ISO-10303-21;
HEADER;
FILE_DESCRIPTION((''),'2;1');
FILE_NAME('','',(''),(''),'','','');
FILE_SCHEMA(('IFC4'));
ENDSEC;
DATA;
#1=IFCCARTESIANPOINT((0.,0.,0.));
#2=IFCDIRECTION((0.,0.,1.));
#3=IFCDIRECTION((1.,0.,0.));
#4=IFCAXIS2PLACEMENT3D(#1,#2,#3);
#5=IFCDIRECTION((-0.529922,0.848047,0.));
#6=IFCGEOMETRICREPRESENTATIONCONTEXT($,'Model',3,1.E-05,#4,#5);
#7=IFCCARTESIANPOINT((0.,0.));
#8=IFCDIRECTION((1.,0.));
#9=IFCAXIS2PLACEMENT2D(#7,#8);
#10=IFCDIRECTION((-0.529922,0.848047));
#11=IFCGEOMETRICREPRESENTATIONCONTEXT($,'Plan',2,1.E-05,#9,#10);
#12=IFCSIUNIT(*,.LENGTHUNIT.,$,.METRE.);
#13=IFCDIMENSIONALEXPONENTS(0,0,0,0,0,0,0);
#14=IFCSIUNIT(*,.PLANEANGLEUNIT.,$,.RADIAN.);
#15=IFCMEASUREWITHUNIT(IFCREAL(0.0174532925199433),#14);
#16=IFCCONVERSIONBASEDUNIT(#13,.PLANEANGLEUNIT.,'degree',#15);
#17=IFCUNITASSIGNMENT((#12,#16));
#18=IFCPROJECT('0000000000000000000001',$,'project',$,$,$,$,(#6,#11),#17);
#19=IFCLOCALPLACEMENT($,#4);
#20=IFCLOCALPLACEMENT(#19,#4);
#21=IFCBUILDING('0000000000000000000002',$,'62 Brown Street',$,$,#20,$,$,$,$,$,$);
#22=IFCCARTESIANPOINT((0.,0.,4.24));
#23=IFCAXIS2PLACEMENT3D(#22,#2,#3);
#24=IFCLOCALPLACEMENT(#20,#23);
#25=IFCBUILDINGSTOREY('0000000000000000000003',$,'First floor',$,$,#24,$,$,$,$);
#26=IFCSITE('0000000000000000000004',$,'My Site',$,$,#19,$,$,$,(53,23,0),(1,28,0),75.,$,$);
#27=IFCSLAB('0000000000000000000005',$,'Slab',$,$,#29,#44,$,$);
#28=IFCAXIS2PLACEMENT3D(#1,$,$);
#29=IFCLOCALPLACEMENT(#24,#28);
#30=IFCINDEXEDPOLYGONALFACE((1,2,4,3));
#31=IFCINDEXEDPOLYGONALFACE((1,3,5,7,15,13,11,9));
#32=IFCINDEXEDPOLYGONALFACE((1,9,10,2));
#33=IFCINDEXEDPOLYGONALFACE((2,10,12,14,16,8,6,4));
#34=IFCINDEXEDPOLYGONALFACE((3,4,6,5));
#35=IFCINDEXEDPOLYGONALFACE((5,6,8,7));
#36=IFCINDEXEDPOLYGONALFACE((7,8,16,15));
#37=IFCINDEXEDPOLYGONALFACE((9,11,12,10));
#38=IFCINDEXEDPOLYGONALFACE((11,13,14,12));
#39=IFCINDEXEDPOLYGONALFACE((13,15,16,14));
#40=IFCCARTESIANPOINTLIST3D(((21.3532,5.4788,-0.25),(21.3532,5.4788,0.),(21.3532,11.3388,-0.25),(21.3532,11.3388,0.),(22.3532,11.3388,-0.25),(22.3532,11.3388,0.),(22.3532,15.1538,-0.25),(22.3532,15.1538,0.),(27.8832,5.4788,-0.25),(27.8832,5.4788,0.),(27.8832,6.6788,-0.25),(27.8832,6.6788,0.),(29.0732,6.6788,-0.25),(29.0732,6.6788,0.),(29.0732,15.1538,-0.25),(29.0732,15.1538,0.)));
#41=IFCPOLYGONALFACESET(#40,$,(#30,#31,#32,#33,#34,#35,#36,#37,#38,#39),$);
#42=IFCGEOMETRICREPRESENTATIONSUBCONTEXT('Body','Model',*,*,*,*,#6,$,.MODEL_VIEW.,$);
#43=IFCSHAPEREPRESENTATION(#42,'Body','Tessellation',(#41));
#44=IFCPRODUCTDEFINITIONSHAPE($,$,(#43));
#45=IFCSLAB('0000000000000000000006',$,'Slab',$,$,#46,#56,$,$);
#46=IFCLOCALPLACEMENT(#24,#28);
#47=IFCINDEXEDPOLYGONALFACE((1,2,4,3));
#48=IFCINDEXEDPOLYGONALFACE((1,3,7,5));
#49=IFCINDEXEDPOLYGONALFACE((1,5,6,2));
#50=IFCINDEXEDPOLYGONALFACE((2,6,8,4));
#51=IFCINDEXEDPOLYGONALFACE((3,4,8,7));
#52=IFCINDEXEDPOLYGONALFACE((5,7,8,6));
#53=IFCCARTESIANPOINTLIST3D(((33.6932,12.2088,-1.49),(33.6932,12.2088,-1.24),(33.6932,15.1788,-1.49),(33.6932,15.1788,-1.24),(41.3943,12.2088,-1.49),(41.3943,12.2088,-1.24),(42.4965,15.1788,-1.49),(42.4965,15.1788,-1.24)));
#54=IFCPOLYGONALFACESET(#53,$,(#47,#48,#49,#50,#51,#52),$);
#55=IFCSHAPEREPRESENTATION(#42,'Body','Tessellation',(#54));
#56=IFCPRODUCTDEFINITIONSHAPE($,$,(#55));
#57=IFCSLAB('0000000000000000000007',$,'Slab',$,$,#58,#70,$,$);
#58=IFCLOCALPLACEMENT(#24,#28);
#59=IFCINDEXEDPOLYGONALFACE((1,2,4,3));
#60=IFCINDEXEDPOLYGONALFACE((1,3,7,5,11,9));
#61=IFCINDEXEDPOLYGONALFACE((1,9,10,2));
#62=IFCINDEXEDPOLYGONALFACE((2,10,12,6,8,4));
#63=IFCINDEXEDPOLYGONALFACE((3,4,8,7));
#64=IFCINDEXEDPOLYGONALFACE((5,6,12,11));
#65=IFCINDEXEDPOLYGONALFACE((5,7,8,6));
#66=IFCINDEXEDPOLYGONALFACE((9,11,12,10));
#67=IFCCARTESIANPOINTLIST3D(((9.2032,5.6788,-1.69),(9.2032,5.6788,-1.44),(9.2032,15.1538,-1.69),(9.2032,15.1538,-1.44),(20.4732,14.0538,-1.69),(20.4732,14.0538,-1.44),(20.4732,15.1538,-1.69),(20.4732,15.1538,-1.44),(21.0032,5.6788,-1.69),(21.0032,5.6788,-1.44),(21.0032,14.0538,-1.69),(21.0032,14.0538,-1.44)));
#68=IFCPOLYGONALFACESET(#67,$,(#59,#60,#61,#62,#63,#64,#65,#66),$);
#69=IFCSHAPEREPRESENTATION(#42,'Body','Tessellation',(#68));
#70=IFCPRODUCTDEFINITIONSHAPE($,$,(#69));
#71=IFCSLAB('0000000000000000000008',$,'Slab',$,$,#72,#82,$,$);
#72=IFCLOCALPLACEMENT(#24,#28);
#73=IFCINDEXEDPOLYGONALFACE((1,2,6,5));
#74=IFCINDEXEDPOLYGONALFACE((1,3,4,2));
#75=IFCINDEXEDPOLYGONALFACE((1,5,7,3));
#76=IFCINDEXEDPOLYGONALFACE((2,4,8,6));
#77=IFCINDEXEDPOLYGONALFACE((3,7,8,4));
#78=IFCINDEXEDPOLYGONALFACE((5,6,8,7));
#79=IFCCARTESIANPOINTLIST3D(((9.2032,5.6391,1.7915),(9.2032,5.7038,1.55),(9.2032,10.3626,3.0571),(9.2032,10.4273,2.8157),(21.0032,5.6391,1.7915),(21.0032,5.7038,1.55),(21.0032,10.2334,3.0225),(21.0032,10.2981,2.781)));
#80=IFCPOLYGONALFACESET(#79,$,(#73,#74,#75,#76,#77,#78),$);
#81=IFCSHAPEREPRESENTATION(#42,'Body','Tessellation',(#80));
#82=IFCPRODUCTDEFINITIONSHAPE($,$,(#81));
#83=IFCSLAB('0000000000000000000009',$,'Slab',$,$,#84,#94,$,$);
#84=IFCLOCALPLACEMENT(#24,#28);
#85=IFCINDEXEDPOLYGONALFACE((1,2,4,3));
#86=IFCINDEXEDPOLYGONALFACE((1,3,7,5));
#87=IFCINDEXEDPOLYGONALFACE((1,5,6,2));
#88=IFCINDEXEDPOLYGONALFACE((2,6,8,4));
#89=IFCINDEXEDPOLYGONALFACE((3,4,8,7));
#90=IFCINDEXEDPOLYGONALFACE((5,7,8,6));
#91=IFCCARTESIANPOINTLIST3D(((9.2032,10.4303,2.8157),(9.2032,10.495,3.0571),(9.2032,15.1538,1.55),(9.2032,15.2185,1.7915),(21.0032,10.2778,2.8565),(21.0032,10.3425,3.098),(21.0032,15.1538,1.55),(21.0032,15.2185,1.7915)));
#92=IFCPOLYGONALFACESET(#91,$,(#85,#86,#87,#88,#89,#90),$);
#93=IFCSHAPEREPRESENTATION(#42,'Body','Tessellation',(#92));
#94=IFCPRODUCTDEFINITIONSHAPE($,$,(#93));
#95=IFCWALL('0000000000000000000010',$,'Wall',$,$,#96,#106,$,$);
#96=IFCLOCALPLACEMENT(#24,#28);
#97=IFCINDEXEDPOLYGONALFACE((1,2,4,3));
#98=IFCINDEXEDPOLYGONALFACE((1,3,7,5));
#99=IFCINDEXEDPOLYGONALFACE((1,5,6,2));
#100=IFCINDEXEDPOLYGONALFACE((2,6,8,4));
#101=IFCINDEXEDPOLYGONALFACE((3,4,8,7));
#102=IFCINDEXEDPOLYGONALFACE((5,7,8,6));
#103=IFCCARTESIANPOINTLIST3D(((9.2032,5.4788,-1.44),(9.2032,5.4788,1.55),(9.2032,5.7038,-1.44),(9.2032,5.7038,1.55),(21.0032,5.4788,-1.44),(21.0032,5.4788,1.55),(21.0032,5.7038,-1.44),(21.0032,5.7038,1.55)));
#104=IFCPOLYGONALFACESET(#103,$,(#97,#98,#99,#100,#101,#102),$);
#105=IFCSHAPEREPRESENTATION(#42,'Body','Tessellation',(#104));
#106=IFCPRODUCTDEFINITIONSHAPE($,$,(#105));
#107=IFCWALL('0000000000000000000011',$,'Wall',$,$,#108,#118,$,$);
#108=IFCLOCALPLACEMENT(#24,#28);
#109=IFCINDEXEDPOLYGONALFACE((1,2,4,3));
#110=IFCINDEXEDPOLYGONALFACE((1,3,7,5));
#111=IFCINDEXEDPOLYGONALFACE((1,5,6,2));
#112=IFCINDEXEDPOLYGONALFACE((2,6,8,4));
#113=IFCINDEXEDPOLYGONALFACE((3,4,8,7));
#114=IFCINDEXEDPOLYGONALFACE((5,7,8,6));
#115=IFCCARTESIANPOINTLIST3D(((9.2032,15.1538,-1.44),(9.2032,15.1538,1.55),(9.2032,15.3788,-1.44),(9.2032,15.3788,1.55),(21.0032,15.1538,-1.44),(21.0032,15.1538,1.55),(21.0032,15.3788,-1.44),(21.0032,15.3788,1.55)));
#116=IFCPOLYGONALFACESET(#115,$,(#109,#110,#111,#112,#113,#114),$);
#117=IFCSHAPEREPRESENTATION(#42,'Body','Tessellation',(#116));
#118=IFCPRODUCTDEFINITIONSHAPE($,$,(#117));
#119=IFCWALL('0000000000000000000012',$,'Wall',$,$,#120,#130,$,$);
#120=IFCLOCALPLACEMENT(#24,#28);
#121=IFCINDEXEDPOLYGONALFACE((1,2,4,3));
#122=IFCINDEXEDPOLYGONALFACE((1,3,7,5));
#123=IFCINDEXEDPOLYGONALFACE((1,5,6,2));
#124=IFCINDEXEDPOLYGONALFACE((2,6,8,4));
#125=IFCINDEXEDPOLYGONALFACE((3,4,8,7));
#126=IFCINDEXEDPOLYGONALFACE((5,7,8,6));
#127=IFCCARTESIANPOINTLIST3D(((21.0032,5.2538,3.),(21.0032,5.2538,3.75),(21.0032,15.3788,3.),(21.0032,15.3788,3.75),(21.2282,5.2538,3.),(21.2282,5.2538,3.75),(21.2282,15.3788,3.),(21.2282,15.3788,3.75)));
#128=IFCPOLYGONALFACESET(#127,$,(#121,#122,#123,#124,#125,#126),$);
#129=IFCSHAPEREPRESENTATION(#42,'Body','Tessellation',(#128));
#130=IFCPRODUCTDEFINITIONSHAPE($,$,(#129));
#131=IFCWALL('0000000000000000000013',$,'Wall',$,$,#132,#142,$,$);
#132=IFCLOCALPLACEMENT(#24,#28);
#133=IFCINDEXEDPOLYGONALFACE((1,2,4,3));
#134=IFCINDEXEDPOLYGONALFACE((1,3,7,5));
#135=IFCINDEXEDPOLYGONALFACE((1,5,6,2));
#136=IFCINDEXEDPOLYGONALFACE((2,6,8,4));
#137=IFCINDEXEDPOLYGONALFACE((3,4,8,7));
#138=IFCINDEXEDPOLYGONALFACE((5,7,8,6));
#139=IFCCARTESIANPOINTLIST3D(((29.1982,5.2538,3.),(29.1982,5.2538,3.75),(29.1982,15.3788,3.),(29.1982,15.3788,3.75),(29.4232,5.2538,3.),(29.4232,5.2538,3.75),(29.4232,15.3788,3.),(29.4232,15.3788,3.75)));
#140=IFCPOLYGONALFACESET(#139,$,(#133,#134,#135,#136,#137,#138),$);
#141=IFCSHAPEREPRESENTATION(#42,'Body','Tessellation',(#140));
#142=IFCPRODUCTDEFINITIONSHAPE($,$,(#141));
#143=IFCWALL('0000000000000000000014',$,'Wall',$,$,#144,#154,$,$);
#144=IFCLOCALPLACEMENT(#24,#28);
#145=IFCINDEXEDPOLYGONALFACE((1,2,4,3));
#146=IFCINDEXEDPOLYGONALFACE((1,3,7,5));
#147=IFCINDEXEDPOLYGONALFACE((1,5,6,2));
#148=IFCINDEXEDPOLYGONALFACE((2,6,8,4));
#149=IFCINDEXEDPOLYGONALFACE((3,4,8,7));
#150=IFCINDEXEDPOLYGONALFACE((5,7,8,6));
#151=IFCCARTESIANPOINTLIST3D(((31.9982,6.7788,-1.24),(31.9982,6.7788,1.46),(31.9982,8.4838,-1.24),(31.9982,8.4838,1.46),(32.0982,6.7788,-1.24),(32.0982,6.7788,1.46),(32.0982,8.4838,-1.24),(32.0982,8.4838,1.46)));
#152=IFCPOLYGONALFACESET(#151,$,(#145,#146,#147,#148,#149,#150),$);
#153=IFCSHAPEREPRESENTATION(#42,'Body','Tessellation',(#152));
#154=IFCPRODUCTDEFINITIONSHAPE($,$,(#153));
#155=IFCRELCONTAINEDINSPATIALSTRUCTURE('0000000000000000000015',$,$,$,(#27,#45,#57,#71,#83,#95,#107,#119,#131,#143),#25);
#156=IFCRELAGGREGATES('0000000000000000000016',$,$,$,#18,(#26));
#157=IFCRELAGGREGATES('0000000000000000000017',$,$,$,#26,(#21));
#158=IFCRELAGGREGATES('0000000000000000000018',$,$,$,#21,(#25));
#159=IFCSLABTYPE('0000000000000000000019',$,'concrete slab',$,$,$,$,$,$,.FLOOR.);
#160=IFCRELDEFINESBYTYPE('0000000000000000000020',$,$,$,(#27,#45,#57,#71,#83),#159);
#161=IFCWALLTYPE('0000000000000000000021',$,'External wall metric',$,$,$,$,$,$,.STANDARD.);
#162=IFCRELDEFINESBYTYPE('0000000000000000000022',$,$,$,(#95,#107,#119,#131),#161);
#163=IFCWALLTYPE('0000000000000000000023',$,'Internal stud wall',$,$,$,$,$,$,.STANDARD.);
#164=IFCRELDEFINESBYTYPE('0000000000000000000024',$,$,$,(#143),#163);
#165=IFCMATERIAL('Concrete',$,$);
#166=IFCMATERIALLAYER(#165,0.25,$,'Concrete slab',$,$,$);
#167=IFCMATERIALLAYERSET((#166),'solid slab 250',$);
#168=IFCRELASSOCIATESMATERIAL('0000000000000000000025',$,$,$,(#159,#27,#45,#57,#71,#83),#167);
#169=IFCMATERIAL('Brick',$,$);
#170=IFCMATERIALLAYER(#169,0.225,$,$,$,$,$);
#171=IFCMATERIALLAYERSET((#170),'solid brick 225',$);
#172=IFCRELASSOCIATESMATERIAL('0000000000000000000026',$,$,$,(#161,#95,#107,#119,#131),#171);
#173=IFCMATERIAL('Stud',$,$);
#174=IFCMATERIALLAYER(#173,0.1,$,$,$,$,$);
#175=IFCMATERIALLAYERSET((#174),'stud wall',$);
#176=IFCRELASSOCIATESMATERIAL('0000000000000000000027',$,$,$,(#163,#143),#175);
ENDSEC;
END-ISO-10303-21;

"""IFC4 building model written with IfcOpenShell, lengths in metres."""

from ifc_helpers import new_model, entity, si_unit, converted_unit, direction, frame, origin_with_axes, origin_2d_with_axis, place, context, subcontext, project, spatial, line, indexed_curve, outline, extrude, material, layer, layer_set, layer_usage, type_object, element, save


model = new_model("IFC4")

# Units and contexts
model_context = context("Model", 3, precision=1e-05, world=origin_with_axes(), true_north=direction((-0.529922, 0.848047, 0.0)))
plan_context = context("Plan", 2, precision=1e-05, world=origin_2d_with_axis(), true_north=direction((-0.529922, 0.848047)))
body_context_1 = subcontext(model_context, "Body", "Model", "MODEL_VIEW")
ifc_project = project(units=[si_unit("LENGTHUNIT", "METRE"), converted_unit("PLANEANGLEUNIT", "degree", entity("IfcReal", 0.0174532925199433), si_unit("PLANEANGLEUNIT", "RADIAN"), dimensions=[0, 0, 0, 0, 0, 0, 0])], contexts=[model_context, plan_context])

# Site, building, storey
site_placement = place(None, origin_with_axes())
site = spatial("IfcSite", under=ifc_project, at=site_placement, Name="My Site", RefLatitude=(53, 23, 0), RefLongitude=(1, 28, 0), RefElevation=75.0)
building_placement = place(site_placement, origin_with_axes())
building = spatial("IfcBuilding", under=site, at=building_placement, Name="62 Brown Street")
storey_placement = place(building_placement, frame((0.0, 0.0, 4.24), z_axis=(0.0, 0.0, 1.0), x_axis=(1.0, 0.0, 0.0)))
storey = spatial("IfcBuildingStorey", under=building, at=storey_placement, Name="First floor")

# Shared definitions
ifc_material_1 = material(Name="Concrete")

# Slabs
ifc_layer_1 = layer(ifc_material_1, 0.25, Name="Concrete slab")
ifc_layer_set_1 = layer_set([ifc_layer_1], Name="solid slab 250")
ifc_layer_usage_1 = layer_usage(ifc_layer_set_1, "AXIS3", "POSITIVE", 0.0)
slab_type = type_object("IfcSlabType", Name="concrete slab", PredefinedType="FLOOR", material=ifc_layer_set_1)
slab_1_placement = place(storey_placement, frame((21.3532, 5.4788, -0.25), z_axis=(0.0, 0.0, 1.0), x_axis=(1.0, 0.0, 0.0)))
element("IfcSlab", 1, at=slab_1_placement, inside=storey, type_object=slab_type, material=ifc_layer_usage_1, Name="Slab", context=body_context_1, shape_type="SweptSolid", body=[
    extrude(outline(indexed_curve([(6.53, 1.2), (7.72, 1.2), (7.72, 9.675), (1.0, 9.675), (1.0, 5.86), (0.0, 5.86), (0.0, 0.0), (6.53, 0.0), (6.53, 1.2)])), None, (0.0, 0.0, 1.0), 0.25),
])
ifc_layer_usage_2 = layer_usage(ifc_layer_set_1, "AXIS3", "POSITIVE", 0.0)
slab_2_placement = place(storey_placement, frame((33.6932, 12.2088, -1.49), z_axis=(0.0, 0.0, 1.0), x_axis=(1.0, 0.0, 0.0)))
element("IfcSlab", 2, at=slab_2_placement, inside=storey, type_object=slab_type, material=ifc_layer_usage_2, Name="Slab", context=body_context_1, shape_type="SweptSolid", body=[
    extrude(outline(indexed_curve([(8.8033, 2.97), (7.7011, 0.0), (0.0, 0.0), (0.0, 2.97)], segments=[line(4, 1), line(1, 2), line(2, 3), line(3, 4)], self_intersect=False)), None, (0.0, 0.0, 1.0), 0.25),
])
ifc_layer_usage_3 = layer_usage(ifc_layer_set_1, "AXIS3", "POSITIVE", 0.0)
slab_3_placement = place(storey_placement, frame((9.2032, 5.6788, -1.69), z_axis=(0.0, 0.0, 1.0), x_axis=(1.0, 0.0, 0.0)))
element("IfcSlab", 3, at=slab_3_placement, inside=storey, type_object=slab_type, material=ifc_layer_usage_3, Name="Slab", context=body_context_1, shape_type="SweptSolid", body=[
    extrude(outline(indexed_curve([(11.27, 9.475), (11.8, 0.0), (0.0, 0.0), (0.0, 9.475), (11.8, 8.375), (11.27, 8.375)], segments=[line(6, 1), line(1, 4), line(4, 3), line(3, 2), line(2, 5), line(5, 6)], self_intersect=False)), None, (0.0, 0.0, 1.0), 0.25),
])
ifc_layer_usage_4 = layer_usage(ifc_layer_set_1, "AXIS3", "POSITIVE", 0.0)
slab_4_placement = place(storey_placement, frame((9.2032, 5.7038, 1.55), z_axis=(0.0, -0.258819, 0.965926), x_axis=(1.0, 0.0, 0.0)))
element("IfcSlab", 4, at=slab_4_placement, inside=storey, type_object=slab_type, material=ifc_layer_usage_4, Name="Slab", context=body_context_1, shape_type="SweptSolid", body=[
    extrude(outline(indexed_curve([(0.0, 4.8901), (0.0, 0.0), (11.8, 0.0), (11.8, 4.7563)], segments=[line(3, 2), line(2, 1), line(1, 4), line(4, 3)], self_intersect=False)), None, (0.0, 0.0, 1.0), 0.25),
])
ifc_layer_usage_5 = layer_usage(ifc_layer_set_1, "AXIS3", "POSITIVE", 0.0)
slab_5_placement = place(storey_placement, frame((21.0032, 15.1538, 1.55), z_axis=(0.0, 0.258819, 0.965926), x_axis=(-1.0, 0.0, 0.0)))
element("IfcSlab", 5, at=slab_5_placement, inside=storey, type_object=slab_type, material=ifc_layer_usage_5, Name="Slab", context=body_context_1, shape_type="SweptSolid", body=[
    extrude(outline(indexed_curve([(0.0, 0.0), (11.8, 0.0), (11.8, 4.8901), (0.0, 5.048)], segments=[line(4, 1), line(1, 2), line(2, 3), line(3, 4)], self_intersect=False)), None, (0.0, 0.0, 1.0), 0.25),
])

# Walls
ifc_material_2 = material(Name="Brick")
ifc_layer_2 = layer(ifc_material_2, 0.225)
ifc_layer_set_2 = layer_set([ifc_layer_2], Name="solid brick 225")
ifc_layer_usage_6 = layer_usage(ifc_layer_set_2, "AXIS2", "POSITIVE", 0.0)
wall_type_1 = type_object("IfcWallType", Name="External wall metric", PredefinedType="STANDARD", material=ifc_layer_set_2)
wall_1_placement = place(storey_placement, frame((9.2032, 5.4788, -1.44), z_axis=(0.0, 0.0, 1.0), x_axis=(1.0, 0.0, 0.0)))
element("IfcWall", 6, at=wall_1_placement, inside=storey, type_object=wall_type_1, material=ifc_layer_usage_6, Name="Wall", context=body_context_1, shape_type="SweptSolid", body=[
    extrude(outline(indexed_curve([(0.0, 0.0), (0.0, 0.225), (11.8, 0.225), (11.8, 0.0), (0.0, 0.0)], self_intersect=False)), origin_with_axes(), (0.0, 0.0, 1.0), 2.99),
])
ifc_layer_usage_7 = layer_usage(ifc_layer_set_2, "AXIS2", "POSITIVE", 0.0)
wall_2_placement = place(storey_placement, frame((21.0032, 15.3788, -1.44), z_axis=(0.0, 0.0, 1.0), x_axis=(-1.0, 0.0, 0.0)))
element("IfcWall", 7, at=wall_2_placement, inside=storey, type_object=wall_type_1, material=ifc_layer_usage_7, Name="Wall", context=body_context_1, shape_type="SweptSolid", body=[
    extrude(outline(indexed_curve([(0.0, 0.0), (0.0, 0.225), (11.8, 0.225), (11.8, 0.0), (0.0, 0.0)], self_intersect=False)), origin_with_axes(), (0.0, 0.0, 1.0), 2.99),
])
ifc_layer_usage_8 = layer_usage(ifc_layer_set_2, "AXIS2", "POSITIVE", 0.0)
wall_3_placement = place(storey_placement, frame((21.0032, 15.3788, 3.0), z_axis=(0.0, 0.0, 1.0), x_axis=(0.0, -1.0, 0.0)))
element("IfcWall", 8, at=wall_3_placement, inside=storey, type_object=wall_type_1, material=ifc_layer_usage_8, Name="Wall", context=body_context_1, shape_type="SweptSolid", body=[
    extrude(outline(indexed_curve([(0.0, 0.0), (0.0, 0.225), (10.125, 0.225), (10.125, 0.0), (0.0, 0.0)], self_intersect=False)), origin_with_axes(), (0.0, 0.0, 1.0), 0.75),
])
ifc_layer_usage_9 = layer_usage(ifc_layer_set_2, "AXIS2", "POSITIVE", 0.0)
wall_4_placement = place(storey_placement, frame((29.4232, 5.2538, 3.0), z_axis=(0.0, 0.0, 1.0), x_axis=(0.0, 1.0, 0.0)))
element("IfcWall", 9, at=wall_4_placement, inside=storey, type_object=wall_type_1, material=ifc_layer_usage_9, Name="Wall", context=body_context_1, shape_type="SweptSolid", body=[
    extrude(outline(indexed_curve([(0.0, 0.0), (0.0, 0.225), (10.125, 0.225), (10.125, 0.0), (0.0, 0.0)], self_intersect=False)), origin_with_axes(), (0.0, 0.0, 1.0), 0.75),
])
ifc_material_3 = material(Name="Stud")
ifc_layer_3 = layer(ifc_material_3, 0.1)
ifc_layer_set_3 = layer_set([ifc_layer_3], Name="stud wall")
ifc_layer_usage_10 = layer_usage(ifc_layer_set_3, "AXIS2", "POSITIVE", 0.0)
wall_type_2 = type_object("IfcWallType", Name="Internal stud wall", PredefinedType="STANDARD", material=ifc_layer_set_3)
wall_5_placement = place(storey_placement, frame((32.0982, 6.7788, -1.24), z_axis=(0.0, 0.0, 1.0), x_axis=(0.000001, 1.0, 0.0)))
element("IfcWall", 10, at=wall_5_placement, inside=storey, type_object=wall_type_2, material=ifc_layer_usage_10, Name="Wall", context=body_context_1, shape_type="SweptSolid", body=[
    extrude(outline(indexed_curve([(0.0, 0.0), (0.0, 0.1), (1.705, 0.1), (1.705, 0.0), (0.0, 0.0)], self_intersect=False)), origin_with_axes(), (0.0, 0.0, 1.0), 2.7),
])

save(model, "model.ifc")
